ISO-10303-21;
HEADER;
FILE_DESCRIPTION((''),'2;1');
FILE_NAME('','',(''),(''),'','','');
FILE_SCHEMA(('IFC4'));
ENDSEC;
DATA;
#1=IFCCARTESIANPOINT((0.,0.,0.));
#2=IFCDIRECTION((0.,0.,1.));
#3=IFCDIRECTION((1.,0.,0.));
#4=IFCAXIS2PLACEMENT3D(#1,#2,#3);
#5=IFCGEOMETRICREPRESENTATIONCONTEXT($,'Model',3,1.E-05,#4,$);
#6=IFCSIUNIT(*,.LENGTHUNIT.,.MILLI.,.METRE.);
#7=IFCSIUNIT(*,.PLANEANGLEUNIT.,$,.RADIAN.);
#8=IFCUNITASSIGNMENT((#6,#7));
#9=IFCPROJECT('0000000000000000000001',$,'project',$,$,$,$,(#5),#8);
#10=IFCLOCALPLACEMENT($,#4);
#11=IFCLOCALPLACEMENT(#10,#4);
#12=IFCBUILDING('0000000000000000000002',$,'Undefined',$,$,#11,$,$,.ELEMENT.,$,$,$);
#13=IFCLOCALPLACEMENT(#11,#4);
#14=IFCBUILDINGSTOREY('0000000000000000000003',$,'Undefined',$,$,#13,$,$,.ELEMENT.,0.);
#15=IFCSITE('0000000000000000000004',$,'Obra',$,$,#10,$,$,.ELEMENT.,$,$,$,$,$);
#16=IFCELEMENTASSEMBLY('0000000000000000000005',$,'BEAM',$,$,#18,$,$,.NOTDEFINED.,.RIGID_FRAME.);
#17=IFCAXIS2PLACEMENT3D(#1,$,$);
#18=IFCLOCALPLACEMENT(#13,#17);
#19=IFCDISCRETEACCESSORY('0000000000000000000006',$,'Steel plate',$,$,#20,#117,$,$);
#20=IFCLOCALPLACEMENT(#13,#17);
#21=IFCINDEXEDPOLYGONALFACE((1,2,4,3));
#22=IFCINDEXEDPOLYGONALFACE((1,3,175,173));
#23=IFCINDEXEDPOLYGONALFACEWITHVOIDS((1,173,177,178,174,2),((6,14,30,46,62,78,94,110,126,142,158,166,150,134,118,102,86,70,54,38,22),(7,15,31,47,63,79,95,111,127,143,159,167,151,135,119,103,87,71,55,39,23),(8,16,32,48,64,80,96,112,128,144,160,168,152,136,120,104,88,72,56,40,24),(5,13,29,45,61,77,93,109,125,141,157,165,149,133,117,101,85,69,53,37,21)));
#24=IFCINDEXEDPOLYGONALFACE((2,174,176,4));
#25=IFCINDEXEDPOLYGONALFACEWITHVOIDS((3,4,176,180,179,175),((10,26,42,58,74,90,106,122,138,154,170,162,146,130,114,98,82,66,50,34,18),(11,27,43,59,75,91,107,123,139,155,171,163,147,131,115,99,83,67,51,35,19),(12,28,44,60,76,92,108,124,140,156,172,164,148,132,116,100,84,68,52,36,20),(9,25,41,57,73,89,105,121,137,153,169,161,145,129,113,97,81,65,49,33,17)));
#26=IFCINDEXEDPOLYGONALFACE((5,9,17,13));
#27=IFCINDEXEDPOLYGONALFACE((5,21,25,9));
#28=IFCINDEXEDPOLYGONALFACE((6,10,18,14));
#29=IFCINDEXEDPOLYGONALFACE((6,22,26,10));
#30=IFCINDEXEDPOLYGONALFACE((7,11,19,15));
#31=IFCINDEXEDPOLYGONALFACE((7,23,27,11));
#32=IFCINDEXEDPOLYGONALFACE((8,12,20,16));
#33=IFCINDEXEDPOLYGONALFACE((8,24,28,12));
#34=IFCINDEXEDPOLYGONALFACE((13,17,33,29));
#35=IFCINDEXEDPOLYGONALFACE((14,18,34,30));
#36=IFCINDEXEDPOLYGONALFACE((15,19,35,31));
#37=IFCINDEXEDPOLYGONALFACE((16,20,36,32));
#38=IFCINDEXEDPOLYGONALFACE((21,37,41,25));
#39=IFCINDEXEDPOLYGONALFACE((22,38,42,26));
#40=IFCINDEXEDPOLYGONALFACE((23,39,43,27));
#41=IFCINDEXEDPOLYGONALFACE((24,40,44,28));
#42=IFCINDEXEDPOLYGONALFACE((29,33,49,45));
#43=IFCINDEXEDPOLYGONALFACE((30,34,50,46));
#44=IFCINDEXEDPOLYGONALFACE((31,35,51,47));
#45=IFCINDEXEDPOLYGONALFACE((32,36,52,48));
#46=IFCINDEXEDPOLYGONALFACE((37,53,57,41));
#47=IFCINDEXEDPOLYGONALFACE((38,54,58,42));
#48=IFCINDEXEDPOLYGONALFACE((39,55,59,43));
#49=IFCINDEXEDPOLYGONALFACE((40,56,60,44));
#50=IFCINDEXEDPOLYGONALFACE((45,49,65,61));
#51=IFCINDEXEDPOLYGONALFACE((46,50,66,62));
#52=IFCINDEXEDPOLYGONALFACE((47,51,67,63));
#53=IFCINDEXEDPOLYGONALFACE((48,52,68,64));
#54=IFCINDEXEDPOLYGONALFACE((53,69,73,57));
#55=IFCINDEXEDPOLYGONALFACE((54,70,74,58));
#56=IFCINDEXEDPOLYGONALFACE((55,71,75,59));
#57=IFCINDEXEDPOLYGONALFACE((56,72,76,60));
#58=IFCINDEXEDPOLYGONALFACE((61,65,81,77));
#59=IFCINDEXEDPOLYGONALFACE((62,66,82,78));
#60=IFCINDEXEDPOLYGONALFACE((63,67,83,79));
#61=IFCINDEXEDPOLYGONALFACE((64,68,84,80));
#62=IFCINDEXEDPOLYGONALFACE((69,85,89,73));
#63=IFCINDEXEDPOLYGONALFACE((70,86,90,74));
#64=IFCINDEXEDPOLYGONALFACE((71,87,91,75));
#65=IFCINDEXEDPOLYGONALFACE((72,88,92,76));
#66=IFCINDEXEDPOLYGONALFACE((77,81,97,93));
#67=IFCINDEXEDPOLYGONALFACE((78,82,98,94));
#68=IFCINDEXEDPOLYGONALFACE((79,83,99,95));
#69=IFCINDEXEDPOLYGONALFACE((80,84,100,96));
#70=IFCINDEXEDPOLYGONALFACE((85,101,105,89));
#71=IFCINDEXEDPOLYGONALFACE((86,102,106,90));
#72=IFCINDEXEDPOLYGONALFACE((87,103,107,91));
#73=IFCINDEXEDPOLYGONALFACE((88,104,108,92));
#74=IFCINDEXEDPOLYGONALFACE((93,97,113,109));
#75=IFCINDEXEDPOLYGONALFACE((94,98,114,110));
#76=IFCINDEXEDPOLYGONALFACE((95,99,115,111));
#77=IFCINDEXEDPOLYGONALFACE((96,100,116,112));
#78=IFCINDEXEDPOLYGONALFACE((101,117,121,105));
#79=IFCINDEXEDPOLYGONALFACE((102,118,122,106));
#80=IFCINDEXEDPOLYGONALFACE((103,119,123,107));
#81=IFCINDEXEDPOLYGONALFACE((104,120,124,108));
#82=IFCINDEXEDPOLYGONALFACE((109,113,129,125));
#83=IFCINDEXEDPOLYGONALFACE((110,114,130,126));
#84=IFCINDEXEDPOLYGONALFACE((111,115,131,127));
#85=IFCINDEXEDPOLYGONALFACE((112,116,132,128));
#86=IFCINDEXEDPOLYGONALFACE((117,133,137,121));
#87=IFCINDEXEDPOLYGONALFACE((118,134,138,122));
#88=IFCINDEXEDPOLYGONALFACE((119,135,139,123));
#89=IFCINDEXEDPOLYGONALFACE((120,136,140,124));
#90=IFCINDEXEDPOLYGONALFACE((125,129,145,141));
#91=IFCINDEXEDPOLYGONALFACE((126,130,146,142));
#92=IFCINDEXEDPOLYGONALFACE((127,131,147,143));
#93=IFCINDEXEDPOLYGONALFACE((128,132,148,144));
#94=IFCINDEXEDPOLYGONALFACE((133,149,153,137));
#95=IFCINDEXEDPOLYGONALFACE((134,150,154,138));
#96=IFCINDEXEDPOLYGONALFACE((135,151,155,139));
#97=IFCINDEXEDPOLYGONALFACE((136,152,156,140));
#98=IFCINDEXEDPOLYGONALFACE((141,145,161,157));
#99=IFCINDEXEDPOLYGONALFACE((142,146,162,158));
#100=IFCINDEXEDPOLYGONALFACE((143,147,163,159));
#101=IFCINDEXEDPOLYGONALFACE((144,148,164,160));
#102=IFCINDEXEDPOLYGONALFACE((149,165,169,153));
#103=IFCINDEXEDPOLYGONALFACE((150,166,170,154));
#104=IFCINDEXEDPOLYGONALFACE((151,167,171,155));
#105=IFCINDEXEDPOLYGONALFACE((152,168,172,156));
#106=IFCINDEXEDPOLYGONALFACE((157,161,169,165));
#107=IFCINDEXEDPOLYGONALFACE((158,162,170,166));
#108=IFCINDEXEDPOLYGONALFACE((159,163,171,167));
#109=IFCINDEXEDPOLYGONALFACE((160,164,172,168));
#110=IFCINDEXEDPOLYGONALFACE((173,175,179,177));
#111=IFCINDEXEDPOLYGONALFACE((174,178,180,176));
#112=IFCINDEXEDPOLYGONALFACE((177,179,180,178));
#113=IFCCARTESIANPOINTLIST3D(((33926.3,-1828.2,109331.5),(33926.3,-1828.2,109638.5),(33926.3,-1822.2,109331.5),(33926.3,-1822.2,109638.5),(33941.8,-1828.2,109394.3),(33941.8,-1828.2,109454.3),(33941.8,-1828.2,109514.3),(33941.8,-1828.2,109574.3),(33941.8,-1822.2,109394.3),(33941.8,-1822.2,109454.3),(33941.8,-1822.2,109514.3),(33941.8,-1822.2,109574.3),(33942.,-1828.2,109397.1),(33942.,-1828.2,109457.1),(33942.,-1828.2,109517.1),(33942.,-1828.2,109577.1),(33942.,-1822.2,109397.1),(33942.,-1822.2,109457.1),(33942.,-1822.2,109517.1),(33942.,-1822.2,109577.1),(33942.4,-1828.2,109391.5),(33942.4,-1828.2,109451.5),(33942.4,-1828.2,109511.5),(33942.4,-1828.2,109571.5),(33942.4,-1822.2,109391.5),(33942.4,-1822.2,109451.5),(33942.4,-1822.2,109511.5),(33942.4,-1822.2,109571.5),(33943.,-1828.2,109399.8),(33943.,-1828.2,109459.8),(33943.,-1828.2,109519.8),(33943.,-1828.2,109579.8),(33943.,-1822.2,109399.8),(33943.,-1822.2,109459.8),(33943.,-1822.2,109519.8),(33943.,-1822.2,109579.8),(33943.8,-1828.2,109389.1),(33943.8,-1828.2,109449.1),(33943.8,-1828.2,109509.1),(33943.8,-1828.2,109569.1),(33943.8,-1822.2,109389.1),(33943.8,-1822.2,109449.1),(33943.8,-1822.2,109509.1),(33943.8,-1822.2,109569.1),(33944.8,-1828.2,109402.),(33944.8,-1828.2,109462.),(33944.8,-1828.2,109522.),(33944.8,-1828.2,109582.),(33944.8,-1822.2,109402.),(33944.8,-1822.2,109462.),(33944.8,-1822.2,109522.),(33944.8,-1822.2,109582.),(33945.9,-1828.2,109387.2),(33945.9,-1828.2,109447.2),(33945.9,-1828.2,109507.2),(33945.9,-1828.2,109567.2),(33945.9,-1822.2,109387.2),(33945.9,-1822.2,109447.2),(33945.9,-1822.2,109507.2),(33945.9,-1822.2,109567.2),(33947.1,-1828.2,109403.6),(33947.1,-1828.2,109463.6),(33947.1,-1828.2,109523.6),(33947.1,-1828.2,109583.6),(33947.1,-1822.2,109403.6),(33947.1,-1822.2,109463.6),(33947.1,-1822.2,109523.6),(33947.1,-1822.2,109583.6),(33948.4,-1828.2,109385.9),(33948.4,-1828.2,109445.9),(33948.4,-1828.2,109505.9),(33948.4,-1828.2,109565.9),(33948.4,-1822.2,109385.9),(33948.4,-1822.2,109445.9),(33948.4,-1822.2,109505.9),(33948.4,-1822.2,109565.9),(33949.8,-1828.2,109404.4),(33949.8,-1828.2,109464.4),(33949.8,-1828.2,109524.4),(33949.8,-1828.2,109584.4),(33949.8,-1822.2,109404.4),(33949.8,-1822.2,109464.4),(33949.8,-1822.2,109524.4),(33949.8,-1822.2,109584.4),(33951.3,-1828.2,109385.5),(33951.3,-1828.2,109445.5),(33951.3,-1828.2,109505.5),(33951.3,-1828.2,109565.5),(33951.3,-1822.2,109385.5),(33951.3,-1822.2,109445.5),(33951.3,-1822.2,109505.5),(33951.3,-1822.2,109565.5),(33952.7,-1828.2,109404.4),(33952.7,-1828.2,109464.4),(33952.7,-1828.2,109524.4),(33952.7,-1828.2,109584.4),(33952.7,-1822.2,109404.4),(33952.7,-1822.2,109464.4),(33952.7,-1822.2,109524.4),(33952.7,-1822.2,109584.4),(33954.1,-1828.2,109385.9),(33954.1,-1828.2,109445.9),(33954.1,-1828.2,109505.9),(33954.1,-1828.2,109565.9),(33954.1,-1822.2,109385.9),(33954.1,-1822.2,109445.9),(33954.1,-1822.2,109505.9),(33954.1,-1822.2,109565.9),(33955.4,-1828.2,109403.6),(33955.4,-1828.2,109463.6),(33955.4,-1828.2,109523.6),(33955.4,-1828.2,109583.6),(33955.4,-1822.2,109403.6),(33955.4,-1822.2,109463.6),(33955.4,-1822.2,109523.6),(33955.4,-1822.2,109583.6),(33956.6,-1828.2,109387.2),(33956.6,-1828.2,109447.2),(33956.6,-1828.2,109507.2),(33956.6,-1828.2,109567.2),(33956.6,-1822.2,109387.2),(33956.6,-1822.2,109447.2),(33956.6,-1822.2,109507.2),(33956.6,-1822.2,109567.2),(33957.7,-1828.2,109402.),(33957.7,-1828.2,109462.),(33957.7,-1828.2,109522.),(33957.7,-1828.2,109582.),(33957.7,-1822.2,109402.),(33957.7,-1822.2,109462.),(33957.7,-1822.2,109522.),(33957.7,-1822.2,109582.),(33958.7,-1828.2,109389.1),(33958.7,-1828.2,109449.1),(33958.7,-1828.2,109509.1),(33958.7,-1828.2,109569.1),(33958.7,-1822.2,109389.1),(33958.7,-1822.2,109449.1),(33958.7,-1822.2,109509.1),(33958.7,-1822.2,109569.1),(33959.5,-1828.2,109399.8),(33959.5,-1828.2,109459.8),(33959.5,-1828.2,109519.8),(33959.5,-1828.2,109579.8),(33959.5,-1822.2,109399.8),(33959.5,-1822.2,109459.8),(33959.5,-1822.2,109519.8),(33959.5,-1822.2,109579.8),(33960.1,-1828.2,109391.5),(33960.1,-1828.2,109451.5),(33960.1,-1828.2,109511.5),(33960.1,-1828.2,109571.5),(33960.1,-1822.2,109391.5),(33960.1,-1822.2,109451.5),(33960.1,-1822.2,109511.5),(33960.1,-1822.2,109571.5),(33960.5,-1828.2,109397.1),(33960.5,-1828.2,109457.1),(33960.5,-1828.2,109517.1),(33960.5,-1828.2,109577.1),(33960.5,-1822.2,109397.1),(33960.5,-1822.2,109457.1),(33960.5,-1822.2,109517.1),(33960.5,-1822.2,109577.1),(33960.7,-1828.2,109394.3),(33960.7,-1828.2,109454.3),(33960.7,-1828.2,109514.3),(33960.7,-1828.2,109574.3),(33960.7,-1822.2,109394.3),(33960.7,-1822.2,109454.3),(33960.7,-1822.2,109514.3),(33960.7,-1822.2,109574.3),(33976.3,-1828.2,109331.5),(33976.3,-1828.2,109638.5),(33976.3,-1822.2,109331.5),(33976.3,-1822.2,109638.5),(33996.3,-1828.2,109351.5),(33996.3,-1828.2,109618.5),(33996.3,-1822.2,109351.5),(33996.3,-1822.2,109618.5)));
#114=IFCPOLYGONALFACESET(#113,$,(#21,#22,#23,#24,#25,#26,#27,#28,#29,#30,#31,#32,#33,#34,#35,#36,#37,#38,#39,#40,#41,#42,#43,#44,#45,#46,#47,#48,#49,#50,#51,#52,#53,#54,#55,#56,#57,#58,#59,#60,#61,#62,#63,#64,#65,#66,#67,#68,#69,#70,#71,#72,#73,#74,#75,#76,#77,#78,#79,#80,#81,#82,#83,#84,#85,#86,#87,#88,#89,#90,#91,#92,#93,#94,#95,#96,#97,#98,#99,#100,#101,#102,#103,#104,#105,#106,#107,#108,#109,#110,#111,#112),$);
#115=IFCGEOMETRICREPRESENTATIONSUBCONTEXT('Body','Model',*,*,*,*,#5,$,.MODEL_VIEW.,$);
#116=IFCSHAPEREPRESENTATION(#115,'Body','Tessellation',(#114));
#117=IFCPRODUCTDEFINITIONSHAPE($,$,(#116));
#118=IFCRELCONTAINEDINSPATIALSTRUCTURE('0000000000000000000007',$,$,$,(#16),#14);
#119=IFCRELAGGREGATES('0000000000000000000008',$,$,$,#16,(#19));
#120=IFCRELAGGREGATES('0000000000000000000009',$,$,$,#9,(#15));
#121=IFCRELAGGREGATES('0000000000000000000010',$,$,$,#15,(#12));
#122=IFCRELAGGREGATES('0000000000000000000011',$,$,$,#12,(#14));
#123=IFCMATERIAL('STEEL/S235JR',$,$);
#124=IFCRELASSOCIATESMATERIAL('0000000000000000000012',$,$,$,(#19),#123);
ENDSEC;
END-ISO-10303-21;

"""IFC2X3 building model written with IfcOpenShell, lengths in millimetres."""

from ifc_helpers import new_model, si_unit, frame, origin_with_axes, origin_2d_with_axis, place, context, subcontext, project, spatial, polyline, circle, outline, extrude, source, transform, mapped, material, element, aggregate, save


model = new_model("IFC2X3")

# Units and contexts
model_context = context("Model", 3, precision=1e-05, world=origin_with_axes())
body_context = subcontext(model_context, "Body", "Model", "MODEL_VIEW")
ifc_project = project(units=[si_unit("LENGTHUNIT", "METRE", prefix="MILLI"), si_unit("PLANEANGLEUNIT", "RADIAN")], contexts=[model_context])

# Site, building, storey
site_placement = place(None, origin_with_axes())
site = spatial("IfcSite", under=ifc_project, at=site_placement, Name="Obra", CompositionType="ELEMENT")
building_placement = place(site_placement, origin_with_axes())
building = spatial("IfcBuilding", under=site, at=building_placement, Name="Undefined", CompositionType="ELEMENT")
storey_placement = place(building_placement, origin_with_axes())
storey = spatial("IfcBuildingStorey", under=building, at=storey_placement, Name="Undefined", CompositionType="ELEMENT", Elevation=0.0)

# Element assembly, discrete accessory, opening
ifc_material = material(Name="STEEL/S235JR")
shared_shape = source(origin_with_axes(), body_context, "Body", "SweptSolid", [
    extrude(circle(Radius=9.5, at=origin_2d_with_axis()), frame((0.0, -9.8, 0.0), z_axis=(0.0, 1.0, 0.0), x_axis=(1.0, 0.0, 0.0)), (0.0, 0.0, 1.0), 6.2),
])
assembly_1_placement = place(storey_placement, origin_with_axes())
assembly_1 = element("IfcElementAssembly", 1, at=assembly_1_placement, inside=storey, Name="BEAM", AssemblyPlace="NOTDEFINED", PredefinedType="RIGID_FRAME")
discrete_accessory_1_placement = place(assembly_1_placement, frame((33926.3, -1825.2, 109331.5), z_axis=(-0.000001, -1.0, 0.0), x_axis=(1.0, -0.000001, 0.0)))
discrete_accessory_1 = element("IfcDiscreteAccessory", 2, at=discrete_accessory_1_placement, material=ifc_material, Name="Steel plate", context=body_context, shape_type="SweptSolid", body=[
    extrude(outline(polyline([(0.0, 0.0), (50.0, 0.0), (70.0, 20.0), (70.0, 287.0), (50.0, 307.0), (0.0, 307.0), (0.0, 0.0)])), frame((0.0, 0.0, -3.0), z_axis=(0.0, 0.0, 1.0), x_axis=(1.0, 0.0, 0.0)), (0.0, 0.0, 1.0), 6.0),
])
opening_1_placement = place(assembly_1_placement, frame((33986.3, -1832.0, 109650.0), z_axis=(-1.0, 0.000001, 0.0), x_axis=(0.0, 0.0, -1.0)))
element("IfcOpeningElement", 3, at=opening_1_placement, cuts=discrete_accessory_1, ObjectType="Opening", context=body_context, shape_type="MappedRepresentation", body=[
    mapped(shared_shape, transform((75.0, 0.0, 35.0))),
    mapped(shared_shape, transform((135.0, 0.0, 35.0))),
    mapped(shared_shape, transform((195.0, 0.0, 35.0))),
    mapped(shared_shape, transform((255.0, 0.0, 35.0))),
])
aggregate(assembly_1, [discrete_accessory_1])

save(model, "model.ifc")
